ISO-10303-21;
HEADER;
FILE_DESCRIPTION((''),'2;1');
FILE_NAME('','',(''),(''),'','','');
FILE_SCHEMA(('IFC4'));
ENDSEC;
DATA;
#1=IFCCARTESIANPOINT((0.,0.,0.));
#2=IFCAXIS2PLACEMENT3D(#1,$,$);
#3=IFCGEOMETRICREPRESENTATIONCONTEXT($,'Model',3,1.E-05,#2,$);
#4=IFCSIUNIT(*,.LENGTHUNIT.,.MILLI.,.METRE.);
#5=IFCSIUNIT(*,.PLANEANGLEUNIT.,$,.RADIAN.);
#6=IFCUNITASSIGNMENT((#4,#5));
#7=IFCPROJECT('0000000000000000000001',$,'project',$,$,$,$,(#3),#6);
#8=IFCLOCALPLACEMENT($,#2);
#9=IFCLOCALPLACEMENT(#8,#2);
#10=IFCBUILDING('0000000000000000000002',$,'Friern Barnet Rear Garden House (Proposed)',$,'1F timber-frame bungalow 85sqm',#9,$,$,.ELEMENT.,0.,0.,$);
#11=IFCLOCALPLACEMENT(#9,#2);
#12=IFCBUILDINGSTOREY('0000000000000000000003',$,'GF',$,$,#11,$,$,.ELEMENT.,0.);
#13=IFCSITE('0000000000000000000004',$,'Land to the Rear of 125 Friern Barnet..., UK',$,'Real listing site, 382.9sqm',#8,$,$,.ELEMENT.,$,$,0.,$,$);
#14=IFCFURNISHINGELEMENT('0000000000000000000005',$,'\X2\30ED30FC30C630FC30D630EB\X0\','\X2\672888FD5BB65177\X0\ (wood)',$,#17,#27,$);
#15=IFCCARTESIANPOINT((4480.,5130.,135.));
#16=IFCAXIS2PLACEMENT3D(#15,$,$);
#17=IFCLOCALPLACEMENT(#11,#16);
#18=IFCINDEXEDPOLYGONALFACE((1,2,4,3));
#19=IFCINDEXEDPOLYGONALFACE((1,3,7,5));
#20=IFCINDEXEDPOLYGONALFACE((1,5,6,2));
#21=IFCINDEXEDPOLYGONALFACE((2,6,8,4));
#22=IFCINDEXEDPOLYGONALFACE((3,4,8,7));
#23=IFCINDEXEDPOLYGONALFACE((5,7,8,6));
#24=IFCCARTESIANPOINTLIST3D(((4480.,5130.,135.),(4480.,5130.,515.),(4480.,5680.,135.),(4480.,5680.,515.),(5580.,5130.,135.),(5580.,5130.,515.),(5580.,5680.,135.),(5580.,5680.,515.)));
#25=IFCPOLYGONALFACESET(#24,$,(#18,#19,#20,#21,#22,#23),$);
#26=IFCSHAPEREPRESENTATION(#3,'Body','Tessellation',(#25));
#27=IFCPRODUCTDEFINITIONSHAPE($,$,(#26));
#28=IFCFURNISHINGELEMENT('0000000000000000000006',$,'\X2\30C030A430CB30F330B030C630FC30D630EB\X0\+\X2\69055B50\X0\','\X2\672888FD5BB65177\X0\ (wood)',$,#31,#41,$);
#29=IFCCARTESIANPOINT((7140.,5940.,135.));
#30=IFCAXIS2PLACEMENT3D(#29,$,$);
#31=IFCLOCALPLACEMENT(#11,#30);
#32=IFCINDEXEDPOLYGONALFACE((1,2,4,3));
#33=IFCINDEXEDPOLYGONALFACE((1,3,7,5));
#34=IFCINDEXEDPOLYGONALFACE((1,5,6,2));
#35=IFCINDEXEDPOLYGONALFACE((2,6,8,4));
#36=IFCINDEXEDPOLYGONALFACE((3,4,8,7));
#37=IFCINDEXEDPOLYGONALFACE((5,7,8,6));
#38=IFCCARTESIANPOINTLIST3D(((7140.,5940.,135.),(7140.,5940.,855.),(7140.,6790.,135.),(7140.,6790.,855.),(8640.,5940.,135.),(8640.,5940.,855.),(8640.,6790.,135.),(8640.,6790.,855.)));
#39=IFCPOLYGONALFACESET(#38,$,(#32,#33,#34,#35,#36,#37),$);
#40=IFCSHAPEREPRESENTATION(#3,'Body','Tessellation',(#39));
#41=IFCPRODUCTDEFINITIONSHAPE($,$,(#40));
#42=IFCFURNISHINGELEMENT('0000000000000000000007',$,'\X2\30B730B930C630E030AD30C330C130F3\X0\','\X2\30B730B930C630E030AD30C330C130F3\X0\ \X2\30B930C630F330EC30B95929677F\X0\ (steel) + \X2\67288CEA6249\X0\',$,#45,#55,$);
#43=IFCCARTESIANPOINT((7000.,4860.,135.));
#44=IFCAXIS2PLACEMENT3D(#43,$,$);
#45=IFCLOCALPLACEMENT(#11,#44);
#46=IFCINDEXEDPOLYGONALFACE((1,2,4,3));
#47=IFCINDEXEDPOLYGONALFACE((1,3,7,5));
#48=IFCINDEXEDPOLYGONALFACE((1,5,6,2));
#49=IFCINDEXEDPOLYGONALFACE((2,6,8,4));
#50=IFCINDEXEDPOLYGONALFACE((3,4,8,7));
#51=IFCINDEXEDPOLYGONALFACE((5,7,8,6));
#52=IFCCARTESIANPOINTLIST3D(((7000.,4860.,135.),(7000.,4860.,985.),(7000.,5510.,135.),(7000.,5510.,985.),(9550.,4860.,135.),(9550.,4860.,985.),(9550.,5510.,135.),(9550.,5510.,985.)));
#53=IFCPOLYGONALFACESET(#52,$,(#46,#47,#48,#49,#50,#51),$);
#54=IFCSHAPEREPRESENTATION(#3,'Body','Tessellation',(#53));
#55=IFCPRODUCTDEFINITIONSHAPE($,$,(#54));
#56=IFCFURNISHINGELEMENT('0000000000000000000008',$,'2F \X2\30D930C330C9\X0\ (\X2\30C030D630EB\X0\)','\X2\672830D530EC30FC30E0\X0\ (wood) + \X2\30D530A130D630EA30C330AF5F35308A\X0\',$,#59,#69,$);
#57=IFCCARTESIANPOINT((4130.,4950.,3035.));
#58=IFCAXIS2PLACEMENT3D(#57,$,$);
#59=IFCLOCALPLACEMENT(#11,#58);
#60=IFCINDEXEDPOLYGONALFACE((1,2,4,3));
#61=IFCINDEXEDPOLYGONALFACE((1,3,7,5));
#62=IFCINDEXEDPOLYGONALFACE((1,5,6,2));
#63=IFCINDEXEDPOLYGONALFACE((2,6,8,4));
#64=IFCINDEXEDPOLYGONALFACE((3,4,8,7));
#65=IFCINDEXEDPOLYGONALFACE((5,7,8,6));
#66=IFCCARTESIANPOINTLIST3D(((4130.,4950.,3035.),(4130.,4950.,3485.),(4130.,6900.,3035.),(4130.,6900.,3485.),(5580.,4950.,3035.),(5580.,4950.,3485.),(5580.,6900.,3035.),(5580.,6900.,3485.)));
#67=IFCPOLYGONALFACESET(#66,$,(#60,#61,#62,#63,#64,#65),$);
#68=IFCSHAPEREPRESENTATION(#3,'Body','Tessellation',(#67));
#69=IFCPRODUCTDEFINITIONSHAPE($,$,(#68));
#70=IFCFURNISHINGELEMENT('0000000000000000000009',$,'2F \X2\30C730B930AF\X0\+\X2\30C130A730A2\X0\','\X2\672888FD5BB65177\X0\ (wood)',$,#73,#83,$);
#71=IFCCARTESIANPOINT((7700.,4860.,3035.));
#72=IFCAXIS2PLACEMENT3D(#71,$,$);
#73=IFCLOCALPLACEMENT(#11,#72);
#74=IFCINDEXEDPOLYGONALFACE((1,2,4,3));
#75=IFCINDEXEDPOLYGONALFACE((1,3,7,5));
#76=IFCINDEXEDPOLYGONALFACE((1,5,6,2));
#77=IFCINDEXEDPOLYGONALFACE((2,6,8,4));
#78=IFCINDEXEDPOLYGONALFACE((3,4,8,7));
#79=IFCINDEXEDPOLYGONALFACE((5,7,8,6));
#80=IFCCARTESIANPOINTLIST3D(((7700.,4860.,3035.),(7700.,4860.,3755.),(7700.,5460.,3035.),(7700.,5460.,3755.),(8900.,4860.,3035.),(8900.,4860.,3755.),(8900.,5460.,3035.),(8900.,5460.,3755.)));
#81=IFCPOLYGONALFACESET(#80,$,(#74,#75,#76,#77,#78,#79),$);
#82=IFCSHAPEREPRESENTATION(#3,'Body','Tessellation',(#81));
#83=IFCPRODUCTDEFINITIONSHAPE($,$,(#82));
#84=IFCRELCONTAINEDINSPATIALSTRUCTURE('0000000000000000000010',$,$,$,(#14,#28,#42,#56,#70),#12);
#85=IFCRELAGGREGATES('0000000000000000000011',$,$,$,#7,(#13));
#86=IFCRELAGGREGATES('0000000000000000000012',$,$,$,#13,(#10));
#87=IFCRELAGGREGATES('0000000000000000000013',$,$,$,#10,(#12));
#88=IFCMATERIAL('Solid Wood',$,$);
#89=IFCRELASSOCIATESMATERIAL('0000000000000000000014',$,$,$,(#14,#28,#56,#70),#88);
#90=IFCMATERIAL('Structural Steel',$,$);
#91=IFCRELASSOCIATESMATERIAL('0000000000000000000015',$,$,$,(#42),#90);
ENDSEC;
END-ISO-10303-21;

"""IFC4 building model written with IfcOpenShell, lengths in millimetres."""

from ifc_helpers import new_model, si_unit, frame, frame_2d, origin, place, context, project, spatial, rectangle, extrude, material, element, save


model = new_model("IFC4")

# Units and contexts
model_context = context("Model", 3, precision=1e-05, world=origin())
ifc_project = project(units=[si_unit("LENGTHUNIT", "METRE", prefix="MILLI"), si_unit("PLANEANGLEUNIT", "RADIAN")], contexts=[model_context])

# Site, building, storey
site_placement = place(None, origin())
site = spatial("IfcSite", under=ifc_project, at=site_placement, Name="Land to the Rear of 125 Friern Barnet..., UK", ObjectType="Real listing site, 382.9sqm", CompositionType="ELEMENT", RefElevation=0.0)
building_placement = place(site_placement, origin())
building = spatial("IfcBuilding", under=site, at=building_placement, Name="Friern Barnet Rear Garden House (Proposed)", ObjectType="1F timber-frame bungalow 85sqm", CompositionType="ELEMENT", ElevationOfRefHeight=0.0, ElevationOfTerrain=0.0)
storey_placement = place(building_placement, origin())
storey = spatial("IfcBuildingStorey", under=building, at=storey_placement, Name="GF", CompositionType="ELEMENT", Elevation=0.0)

# Shared definitions
ifc_material_1 = material(Name="Solid Wood")

# Shared definitions
ifc_material_2 = material(Name="Structural Steel")

# Furnishing elements
furnishing_1_placement = place(storey_placement, frame((4480.0, 5130.0, 135.0)))
element("IfcFurnishingElement", 1, at=furnishing_1_placement, inside=storey, material=ifc_material_1, Name="ローテーブル", Description="木製家具 (wood)", context=model_context, shape_type="SweptSolid", body=[
    extrude(rectangle(XDim=1100.0, YDim=550.0, at=frame_2d((550.0, 275.0))), frame((4480.0, 5130.0, 135.0)), (0.0, 0.0, 1.0), 380.0),
])
furnishing_2_placement = place(storey_placement, frame((7140.0, 5940.0, 135.0)))
element("IfcFurnishingElement", 2, at=furnishing_2_placement, inside=storey, material=ifc_material_1, Name="ダイニングテーブル+椅子", Description="木製家具 (wood)", context=model_context, shape_type="SweptSolid", body=[
    extrude(rectangle(XDim=1500.0, YDim=850.0, at=frame_2d((750.0, 425.0))), frame((7140.0, 5940.0, 135.0)), (0.0, 0.0, 1.0), 720.0),
])
furnishing_3_placement = place(storey_placement, frame((7000.0, 4860.0, 135.0)))
element("IfcFurnishingElement", 3, at=furnishing_3_placement, inside=storey, material=ifc_material_2, Name="システムキッチン", Description="システムキッチン ステンレス天板 (steel) + 木質扉", context=model_context, shape_type="SweptSolid", body=[
    extrude(rectangle(XDim=2550.0, YDim=650.0, at=frame_2d((1275.0, 325.0))), frame((7000.0, 4860.0, 135.0)), (0.0, 0.0, 1.0), 850.0),
])
furnishing_4_placement = place(storey_placement, frame((4130.0, 4950.0, 3035.0)))
element("IfcFurnishingElement", 4, at=furnishing_4_placement, inside=storey, material=ifc_material_1, Name="2F ベッド (ダブル)", Description="木フレーム (wood) + ファブリック張り", context=model_context, shape_type="SweptSolid", body=[
    extrude(rectangle(XDim=1450.0, YDim=1950.0, at=frame_2d((725.0, 975.0))), frame((4130.0, 4950.0, 3035.0)), (0.0, 0.0, 1.0), 450.0),
])
furnishing_5_placement = place(storey_placement, frame((7700.0, 4860.0, 3035.0)))
element("IfcFurnishingElement", 5, at=furnishing_5_placement, inside=storey, material=ifc_material_1, Name="2F デスク+チェア", Description="木製家具 (wood)", context=model_context, shape_type="SweptSolid", body=[
    extrude(rectangle(XDim=1200.0, YDim=600.0, at=frame_2d((600.0, 300.0))), frame((7700.0, 4860.0, 3035.0)), (0.0, 0.0, 1.0), 720.0),
])

save(model, "model.ifc")
